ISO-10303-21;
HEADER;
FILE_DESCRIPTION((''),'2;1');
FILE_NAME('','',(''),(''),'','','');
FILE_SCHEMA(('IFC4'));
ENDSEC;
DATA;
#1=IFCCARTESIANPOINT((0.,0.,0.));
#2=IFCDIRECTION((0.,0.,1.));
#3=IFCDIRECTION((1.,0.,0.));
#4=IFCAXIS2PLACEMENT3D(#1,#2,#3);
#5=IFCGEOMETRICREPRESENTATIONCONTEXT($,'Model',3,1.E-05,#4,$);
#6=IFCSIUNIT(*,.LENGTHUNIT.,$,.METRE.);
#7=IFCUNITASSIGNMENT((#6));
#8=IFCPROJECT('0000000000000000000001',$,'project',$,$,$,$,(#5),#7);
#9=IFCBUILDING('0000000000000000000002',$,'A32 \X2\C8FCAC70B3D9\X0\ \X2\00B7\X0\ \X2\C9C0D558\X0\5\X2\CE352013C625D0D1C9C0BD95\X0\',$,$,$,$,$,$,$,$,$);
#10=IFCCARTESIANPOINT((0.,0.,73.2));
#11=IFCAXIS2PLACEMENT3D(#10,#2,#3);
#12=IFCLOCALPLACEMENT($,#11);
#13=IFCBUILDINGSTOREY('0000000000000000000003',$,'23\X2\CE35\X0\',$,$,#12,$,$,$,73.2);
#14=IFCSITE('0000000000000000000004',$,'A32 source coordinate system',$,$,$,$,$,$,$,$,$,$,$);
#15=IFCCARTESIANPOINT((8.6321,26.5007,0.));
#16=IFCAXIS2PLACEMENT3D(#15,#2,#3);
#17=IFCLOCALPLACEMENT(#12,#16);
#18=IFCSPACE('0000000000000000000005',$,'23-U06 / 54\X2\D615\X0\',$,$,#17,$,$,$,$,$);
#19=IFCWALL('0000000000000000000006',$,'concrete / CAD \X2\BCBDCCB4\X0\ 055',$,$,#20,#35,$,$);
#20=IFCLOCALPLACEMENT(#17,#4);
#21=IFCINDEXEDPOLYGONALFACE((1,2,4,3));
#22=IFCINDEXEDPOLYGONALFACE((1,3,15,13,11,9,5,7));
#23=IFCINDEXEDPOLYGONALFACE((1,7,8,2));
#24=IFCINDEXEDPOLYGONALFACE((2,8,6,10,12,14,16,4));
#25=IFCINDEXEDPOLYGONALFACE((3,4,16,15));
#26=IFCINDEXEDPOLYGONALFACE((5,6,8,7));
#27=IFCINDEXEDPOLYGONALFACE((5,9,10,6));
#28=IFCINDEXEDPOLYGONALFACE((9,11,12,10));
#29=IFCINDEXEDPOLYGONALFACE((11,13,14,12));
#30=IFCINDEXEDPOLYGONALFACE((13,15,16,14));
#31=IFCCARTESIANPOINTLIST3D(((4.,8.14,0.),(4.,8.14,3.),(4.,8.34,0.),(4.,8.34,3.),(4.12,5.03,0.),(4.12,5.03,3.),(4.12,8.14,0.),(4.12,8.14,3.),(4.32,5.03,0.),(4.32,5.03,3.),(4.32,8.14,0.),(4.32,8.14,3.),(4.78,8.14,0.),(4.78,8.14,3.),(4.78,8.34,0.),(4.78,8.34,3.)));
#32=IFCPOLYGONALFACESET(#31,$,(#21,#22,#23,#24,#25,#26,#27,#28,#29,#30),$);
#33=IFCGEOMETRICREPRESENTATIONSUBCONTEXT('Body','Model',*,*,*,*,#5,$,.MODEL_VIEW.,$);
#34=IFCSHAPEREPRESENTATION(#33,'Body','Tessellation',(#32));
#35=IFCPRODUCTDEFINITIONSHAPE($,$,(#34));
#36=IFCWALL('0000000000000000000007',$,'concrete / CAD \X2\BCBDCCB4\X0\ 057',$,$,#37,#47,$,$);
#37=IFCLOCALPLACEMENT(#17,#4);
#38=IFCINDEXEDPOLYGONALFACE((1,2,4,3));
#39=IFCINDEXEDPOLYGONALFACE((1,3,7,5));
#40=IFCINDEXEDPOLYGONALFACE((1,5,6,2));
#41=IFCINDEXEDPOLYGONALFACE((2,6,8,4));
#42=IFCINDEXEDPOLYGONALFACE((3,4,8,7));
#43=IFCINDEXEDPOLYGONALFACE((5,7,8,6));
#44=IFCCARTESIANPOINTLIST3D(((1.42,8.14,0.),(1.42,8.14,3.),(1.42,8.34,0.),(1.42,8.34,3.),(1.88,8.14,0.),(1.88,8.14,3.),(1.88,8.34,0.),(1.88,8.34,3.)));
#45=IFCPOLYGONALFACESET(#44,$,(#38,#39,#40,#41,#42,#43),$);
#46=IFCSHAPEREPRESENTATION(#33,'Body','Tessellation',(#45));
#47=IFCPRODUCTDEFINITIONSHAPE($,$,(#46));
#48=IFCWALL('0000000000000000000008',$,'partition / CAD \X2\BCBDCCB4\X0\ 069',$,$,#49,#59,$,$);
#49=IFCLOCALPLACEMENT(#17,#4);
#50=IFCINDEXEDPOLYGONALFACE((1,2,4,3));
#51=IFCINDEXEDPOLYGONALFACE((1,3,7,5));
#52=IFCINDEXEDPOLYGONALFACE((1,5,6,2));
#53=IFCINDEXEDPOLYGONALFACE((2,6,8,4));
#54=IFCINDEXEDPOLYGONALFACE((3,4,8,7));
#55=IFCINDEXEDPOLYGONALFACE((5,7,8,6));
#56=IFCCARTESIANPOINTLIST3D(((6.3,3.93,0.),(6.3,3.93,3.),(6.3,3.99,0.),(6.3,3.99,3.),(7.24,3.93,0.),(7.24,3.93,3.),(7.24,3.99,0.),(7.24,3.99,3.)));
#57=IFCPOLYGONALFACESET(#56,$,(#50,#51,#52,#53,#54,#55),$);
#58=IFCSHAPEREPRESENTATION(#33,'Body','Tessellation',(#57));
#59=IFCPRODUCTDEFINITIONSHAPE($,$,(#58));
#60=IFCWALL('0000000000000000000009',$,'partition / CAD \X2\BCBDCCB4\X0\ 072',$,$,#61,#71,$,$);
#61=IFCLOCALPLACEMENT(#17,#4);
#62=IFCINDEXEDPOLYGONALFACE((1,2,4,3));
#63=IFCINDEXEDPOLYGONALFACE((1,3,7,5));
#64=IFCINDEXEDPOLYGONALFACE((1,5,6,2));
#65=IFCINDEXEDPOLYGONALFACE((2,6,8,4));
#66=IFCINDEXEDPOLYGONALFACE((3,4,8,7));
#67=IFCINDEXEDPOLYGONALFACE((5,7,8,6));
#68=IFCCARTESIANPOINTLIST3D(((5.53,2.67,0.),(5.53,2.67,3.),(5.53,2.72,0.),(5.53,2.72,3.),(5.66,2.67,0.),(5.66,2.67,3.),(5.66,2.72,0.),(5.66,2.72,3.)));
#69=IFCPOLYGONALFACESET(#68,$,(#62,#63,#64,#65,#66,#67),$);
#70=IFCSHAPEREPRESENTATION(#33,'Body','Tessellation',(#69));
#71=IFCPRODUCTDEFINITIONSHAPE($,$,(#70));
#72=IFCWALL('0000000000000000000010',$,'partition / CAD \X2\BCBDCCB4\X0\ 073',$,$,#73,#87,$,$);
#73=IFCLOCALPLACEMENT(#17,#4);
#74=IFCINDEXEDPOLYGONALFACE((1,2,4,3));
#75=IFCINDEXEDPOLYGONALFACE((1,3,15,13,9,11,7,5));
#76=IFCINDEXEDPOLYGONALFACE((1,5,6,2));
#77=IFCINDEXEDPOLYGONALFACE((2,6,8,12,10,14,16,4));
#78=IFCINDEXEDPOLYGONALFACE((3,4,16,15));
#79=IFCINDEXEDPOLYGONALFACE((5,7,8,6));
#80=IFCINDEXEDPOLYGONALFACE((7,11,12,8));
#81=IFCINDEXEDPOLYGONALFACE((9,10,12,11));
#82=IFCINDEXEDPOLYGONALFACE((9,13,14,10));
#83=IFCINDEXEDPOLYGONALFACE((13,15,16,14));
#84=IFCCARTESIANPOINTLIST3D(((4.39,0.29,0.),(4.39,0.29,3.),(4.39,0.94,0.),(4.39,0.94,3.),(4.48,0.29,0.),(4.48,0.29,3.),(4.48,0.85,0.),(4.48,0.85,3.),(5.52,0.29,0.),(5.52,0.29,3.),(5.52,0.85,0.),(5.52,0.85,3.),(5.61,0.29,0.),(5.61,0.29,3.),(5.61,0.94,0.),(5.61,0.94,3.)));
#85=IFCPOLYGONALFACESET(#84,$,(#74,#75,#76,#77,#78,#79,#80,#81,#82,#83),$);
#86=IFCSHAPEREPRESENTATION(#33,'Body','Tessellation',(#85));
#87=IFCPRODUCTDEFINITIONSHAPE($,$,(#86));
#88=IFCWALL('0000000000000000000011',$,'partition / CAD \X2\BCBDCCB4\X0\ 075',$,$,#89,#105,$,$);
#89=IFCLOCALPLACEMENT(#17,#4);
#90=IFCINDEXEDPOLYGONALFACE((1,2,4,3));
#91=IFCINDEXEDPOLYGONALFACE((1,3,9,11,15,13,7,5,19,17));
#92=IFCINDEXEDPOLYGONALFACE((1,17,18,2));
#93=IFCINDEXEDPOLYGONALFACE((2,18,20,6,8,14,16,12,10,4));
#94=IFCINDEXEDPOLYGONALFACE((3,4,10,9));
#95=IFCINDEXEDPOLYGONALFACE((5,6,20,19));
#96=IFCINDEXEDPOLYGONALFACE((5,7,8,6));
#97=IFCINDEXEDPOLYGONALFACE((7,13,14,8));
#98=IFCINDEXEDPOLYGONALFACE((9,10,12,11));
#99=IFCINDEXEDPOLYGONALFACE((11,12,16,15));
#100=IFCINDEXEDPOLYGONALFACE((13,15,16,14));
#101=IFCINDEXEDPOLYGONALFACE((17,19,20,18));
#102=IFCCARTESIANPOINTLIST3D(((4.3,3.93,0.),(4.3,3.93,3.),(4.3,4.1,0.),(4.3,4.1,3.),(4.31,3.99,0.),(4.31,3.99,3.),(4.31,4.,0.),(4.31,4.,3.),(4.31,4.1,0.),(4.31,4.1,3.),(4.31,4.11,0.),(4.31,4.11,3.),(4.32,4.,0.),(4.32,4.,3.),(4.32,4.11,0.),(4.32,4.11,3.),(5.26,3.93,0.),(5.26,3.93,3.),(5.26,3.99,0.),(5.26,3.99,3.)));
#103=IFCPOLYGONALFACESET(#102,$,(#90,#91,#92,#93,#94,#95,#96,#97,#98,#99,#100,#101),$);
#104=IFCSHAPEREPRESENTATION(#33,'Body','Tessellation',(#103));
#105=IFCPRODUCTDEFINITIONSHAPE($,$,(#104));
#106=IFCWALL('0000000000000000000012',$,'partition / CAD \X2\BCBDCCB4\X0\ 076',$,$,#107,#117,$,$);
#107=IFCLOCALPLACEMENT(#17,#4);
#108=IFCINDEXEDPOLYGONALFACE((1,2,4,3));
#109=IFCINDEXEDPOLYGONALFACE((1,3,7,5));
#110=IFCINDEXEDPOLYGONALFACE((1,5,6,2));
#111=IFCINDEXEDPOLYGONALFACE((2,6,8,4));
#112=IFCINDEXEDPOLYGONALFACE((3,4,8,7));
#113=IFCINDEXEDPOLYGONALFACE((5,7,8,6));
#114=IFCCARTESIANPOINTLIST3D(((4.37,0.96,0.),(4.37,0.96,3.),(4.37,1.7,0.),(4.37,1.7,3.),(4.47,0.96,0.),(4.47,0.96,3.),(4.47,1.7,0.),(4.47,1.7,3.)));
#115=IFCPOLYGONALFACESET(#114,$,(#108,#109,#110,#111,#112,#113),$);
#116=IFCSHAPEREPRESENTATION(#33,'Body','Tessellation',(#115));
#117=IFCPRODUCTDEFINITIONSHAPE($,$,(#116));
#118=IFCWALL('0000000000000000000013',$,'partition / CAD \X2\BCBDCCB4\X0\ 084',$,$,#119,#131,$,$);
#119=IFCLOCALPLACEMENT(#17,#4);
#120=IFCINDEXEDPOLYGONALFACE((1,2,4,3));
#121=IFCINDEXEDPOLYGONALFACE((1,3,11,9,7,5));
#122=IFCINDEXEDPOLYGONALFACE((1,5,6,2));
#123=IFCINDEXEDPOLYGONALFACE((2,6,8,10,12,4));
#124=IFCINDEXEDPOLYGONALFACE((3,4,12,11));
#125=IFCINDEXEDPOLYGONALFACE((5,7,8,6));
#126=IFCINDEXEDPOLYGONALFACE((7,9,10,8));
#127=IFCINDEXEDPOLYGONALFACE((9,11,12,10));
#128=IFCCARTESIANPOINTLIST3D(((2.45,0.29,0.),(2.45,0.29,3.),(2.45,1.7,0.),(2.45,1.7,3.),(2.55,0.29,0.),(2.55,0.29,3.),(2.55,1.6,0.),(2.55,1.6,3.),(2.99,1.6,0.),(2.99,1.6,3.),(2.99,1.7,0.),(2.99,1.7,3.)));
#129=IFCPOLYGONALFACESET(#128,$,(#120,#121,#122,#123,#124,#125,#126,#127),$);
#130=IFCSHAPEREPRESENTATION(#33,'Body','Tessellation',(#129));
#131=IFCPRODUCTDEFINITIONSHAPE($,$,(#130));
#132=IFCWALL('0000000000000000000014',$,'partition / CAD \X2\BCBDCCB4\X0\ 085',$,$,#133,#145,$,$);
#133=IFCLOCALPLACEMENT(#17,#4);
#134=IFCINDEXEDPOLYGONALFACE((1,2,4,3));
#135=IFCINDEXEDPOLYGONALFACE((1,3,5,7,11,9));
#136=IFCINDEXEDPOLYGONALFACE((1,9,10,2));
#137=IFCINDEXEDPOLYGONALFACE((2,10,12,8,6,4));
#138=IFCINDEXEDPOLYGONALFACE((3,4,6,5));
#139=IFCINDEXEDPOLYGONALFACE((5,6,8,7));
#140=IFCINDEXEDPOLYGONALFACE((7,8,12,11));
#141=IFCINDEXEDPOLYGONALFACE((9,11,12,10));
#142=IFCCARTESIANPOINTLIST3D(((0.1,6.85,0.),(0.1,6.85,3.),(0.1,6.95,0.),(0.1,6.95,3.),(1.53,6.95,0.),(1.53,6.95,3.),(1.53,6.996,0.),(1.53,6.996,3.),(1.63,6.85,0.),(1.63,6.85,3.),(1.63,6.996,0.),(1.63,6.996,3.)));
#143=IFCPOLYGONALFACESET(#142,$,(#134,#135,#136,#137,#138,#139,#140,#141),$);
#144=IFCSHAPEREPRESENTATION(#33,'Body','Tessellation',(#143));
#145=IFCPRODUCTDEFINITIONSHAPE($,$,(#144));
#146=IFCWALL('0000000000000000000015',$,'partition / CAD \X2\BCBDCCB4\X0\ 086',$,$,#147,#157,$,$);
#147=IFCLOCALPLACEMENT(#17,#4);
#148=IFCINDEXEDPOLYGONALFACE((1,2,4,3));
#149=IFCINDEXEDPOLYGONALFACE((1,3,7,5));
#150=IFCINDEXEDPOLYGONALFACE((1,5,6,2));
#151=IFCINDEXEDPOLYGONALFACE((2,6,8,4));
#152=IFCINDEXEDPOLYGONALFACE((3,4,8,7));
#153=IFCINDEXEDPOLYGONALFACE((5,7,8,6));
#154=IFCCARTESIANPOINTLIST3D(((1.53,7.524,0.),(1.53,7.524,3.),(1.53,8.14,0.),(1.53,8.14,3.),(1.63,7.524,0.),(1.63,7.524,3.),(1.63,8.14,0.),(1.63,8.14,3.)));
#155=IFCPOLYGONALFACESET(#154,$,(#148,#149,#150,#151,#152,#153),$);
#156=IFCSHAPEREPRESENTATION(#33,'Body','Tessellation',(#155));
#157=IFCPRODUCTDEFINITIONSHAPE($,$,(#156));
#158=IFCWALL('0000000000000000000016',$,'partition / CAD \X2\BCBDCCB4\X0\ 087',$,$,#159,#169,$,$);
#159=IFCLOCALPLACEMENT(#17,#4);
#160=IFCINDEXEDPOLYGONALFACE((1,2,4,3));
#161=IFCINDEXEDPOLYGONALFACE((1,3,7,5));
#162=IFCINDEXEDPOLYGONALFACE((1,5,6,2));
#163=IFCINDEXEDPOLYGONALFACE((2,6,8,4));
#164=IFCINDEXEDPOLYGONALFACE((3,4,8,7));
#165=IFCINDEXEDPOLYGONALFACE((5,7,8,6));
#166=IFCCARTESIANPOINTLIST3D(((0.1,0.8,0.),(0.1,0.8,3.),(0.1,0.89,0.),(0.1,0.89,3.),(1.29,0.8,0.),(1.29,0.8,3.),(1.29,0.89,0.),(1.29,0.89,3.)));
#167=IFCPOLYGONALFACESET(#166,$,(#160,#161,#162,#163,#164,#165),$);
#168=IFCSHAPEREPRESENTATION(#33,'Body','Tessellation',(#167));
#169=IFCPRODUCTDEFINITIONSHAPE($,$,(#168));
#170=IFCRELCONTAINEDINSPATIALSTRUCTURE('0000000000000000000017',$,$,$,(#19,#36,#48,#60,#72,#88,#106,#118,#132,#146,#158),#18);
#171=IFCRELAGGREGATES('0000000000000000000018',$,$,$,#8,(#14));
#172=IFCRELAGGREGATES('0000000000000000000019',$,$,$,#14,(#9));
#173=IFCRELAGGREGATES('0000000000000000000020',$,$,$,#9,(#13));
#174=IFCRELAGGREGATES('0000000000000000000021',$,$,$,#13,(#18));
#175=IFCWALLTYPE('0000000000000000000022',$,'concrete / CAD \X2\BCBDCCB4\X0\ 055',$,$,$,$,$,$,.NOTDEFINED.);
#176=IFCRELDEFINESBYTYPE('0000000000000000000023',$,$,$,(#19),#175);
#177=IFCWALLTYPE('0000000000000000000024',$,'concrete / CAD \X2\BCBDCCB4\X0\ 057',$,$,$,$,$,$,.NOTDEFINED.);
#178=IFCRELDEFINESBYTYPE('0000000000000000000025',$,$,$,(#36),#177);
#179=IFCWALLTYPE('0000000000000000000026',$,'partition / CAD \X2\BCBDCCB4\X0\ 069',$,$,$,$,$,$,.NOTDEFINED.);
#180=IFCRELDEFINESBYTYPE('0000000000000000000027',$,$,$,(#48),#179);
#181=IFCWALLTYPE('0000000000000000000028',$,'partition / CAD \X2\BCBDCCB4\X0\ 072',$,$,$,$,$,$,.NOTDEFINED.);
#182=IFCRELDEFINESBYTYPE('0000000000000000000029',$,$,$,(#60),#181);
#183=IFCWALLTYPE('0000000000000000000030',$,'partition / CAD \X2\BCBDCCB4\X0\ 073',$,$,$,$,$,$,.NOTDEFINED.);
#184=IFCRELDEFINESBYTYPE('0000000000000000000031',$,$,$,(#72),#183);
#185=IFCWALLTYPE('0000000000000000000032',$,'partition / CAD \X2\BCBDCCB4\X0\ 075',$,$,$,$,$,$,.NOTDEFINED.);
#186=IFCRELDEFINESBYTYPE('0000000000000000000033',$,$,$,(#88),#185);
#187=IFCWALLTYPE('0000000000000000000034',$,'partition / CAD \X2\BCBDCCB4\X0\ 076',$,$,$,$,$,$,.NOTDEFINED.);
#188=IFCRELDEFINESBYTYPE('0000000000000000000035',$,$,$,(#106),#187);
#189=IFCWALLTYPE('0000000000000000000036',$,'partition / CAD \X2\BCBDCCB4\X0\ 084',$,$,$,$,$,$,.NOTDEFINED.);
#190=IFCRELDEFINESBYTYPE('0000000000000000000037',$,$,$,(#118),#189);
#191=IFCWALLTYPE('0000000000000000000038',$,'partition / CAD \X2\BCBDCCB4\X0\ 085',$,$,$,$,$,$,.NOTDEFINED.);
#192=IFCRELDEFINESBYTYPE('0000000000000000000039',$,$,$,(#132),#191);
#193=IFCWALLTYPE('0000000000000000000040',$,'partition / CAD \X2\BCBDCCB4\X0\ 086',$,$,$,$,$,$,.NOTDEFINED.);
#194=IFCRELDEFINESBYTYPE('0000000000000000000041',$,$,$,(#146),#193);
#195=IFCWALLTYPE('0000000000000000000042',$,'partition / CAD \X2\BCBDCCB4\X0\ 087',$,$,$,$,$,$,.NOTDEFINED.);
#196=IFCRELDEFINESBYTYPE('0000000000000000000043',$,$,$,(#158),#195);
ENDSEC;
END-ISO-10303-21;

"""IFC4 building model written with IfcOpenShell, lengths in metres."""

from ifc_helpers import new_model, si_unit, frame, origin, origin_with_axes, place, context, subcontext, project, spatial, polyline, outline, extrude, source, transform, mapped, type_object, type_shapes, element, save


model = new_model("IFC4")

# Units and contexts
model_context = context("Model", 3, precision=1e-05, world=origin_with_axes())
body_context = subcontext(model_context, "Body", "Model", "MODEL_VIEW")
ifc_project = project(units=[si_unit("LENGTHUNIT", "METRE")], contexts=[model_context])

# Site, building, storey, space
site = spatial("IfcSite", under=ifc_project, Name="A32 source coordinate system")
building = spatial("IfcBuilding", under=site, Name="A32 주거동 · 지하5층–옥탑지붕")
storey_placement = place(None, frame((0.0, 0.0, 73.2), z_axis=(0.0, 0.0, 1.0), x_axis=(1.0, 0.0, 0.0)))
storey = spatial("IfcBuildingStorey", under=building, at=storey_placement, Name="23층", Elevation=73.2)
space_placement = place(storey_placement, frame((8.6321, 26.5007, 0.0), z_axis=(0.0, 0.0, 1.0), x_axis=(1.0, 0.0, 0.0)))
space = spatial("IfcSpace", under=storey, at=space_placement, Name="23-U06 / 54형")

# Walls
wall_type_1 = type_object("IfcWallType", Name="concrete / CAD 벽체 055", PredefinedType="NOTDEFINED")
shared_shape_1 = source(origin(), body_context, "Body", "SweptSolid", [
    extrude(outline(polyline([(4.32, 5.03), (4.12, 5.03), (4.12, 8.14), (4.0, 8.14), (4.0, 8.34), (4.78, 8.34), (4.78, 8.14), (4.32, 8.14), (4.32, 5.03)])), origin(), (0.0, 0.0, 1.0), 3.0),
])
type_shapes(wall_type_1, [shared_shape_1])
wall_1_placement = place(space_placement, origin_with_axes())
element("IfcWall", 1, at=wall_1_placement, inside=space, type_object=wall_type_1, Name="concrete / CAD 벽체 055", context=body_context, shape_type="MappedRepresentation", body=[
    mapped(shared_shape_1, transform((0.0, 0.0, 0.0), scale=1.0)),
])
wall_type_2 = type_object("IfcWallType", Name="concrete / CAD 벽체 057", PredefinedType="NOTDEFINED")
shared_shape_2 = source(origin(), body_context, "Body", "SweptSolid", [
    extrude(outline(polyline([(1.42, 8.14), (1.42, 8.34), (1.88, 8.34), (1.88, 8.14), (1.42, 8.14)])), origin(), (0.0, 0.0, 1.0), 3.0),
])
type_shapes(wall_type_2, [shared_shape_2])
wall_2_placement = place(space_placement, origin_with_axes())
element("IfcWall", 2, at=wall_2_placement, inside=space, type_object=wall_type_2, Name="concrete / CAD 벽체 057", context=body_context, shape_type="MappedRepresentation", body=[
    mapped(shared_shape_2, transform((0.0, 0.0, 0.0), scale=1.0)),
])
wall_type_3 = type_object("IfcWallType", Name="partition / CAD 벽체 069", PredefinedType="NOTDEFINED")
shared_shape_3 = source(origin(), body_context, "Body", "SweptSolid", [
    extrude(outline(polyline([(7.24, 3.93), (6.3, 3.93), (6.3, 3.99), (7.24, 3.99), (7.24, 3.93)])), origin(), (0.0, 0.0, 1.0), 3.0),
])
type_shapes(wall_type_3, [shared_shape_3])
wall_3_placement = place(space_placement, origin_with_axes())
element("IfcWall", 3, at=wall_3_placement, inside=space, type_object=wall_type_3, Name="partition / CAD 벽체 069", context=body_context, shape_type="MappedRepresentation", body=[
    mapped(shared_shape_3, transform((0.0, 0.0, 0.0), scale=1.0)),
])
wall_type_4 = type_object("IfcWallType", Name="partition / CAD 벽체 072", PredefinedType="NOTDEFINED")
shared_shape_4 = source(origin(), body_context, "Body", "SweptSolid", [
    extrude(outline(polyline([(5.66, 2.67), (5.53, 2.67), (5.53, 2.72), (5.66, 2.72), (5.66, 2.67)])), origin(), (0.0, 0.0, 1.0), 3.0),
])
type_shapes(wall_type_4, [shared_shape_4])
wall_4_placement = place(space_placement, origin_with_axes())
element("IfcWall", 4, at=wall_4_placement, inside=space, type_object=wall_type_4, Name="partition / CAD 벽체 072", context=body_context, shape_type="MappedRepresentation", body=[
    mapped(shared_shape_4, transform((0.0, 0.0, 0.0), scale=1.0)),
])
wall_type_5 = type_object("IfcWallType", Name="partition / CAD 벽체 073", PredefinedType="NOTDEFINED")
shared_shape_5 = source(origin(), body_context, "Body", "SweptSolid", [
    extrude(outline(polyline([(4.48, 0.29), (4.39, 0.29), (4.39, 0.94), (5.61, 0.94), (5.61, 0.29), (5.52, 0.29), (5.52, 0.85), (4.48, 0.85), (4.48, 0.29)])), origin(), (0.0, 0.0, 1.0), 3.0),
])
type_shapes(wall_type_5, [shared_shape_5])
wall_5_placement = place(space_placement, origin_with_axes())
element("IfcWall", 5, at=wall_5_placement, inside=space, type_object=wall_type_5, Name="partition / CAD 벽체 073", context=body_context, shape_type="MappedRepresentation", body=[
    mapped(shared_shape_5, transform((0.0, 0.0, 0.0), scale=1.0)),
])
wall_type_6 = type_object("IfcWallType", Name="partition / CAD 벽체 075", PredefinedType="NOTDEFINED")
shared_shape_6 = source(origin(), body_context, "Body", "SweptSolid", [
    extrude(outline(polyline([(4.32, 4.0), (4.31, 4.0), (4.31, 3.99), (5.26, 3.99), (5.26, 3.93), (4.3, 3.93), (4.3, 4.1), (4.31, 4.1), (4.31, 4.11), (4.32, 4.11), (4.32, 4.0)])), origin(), (0.0, 0.0, 1.0), 3.0),
])
type_shapes(wall_type_6, [shared_shape_6])
wall_6_placement = place(space_placement, origin_with_axes())
element("IfcWall", 6, at=wall_6_placement, inside=space, type_object=wall_type_6, Name="partition / CAD 벽체 075", context=body_context, shape_type="MappedRepresentation", body=[
    mapped(shared_shape_6, transform((0.0, 0.0, 0.0), scale=1.0)),
])
wall_type_7 = type_object("IfcWallType", Name="partition / CAD 벽체 076", PredefinedType="NOTDEFINED")
shared_shape_7 = source(origin(), body_context, "Body", "SweptSolid", [
    extrude(outline(polyline([(4.37, 1.7), (4.47, 1.7), (4.47, 0.96), (4.37, 0.96), (4.37, 1.7)])), origin(), (0.0, 0.0, 1.0), 3.0),
])
type_shapes(wall_type_7, [shared_shape_7])
wall_7_placement = place(space_placement, origin_with_axes())
element("IfcWall", 7, at=wall_7_placement, inside=space, type_object=wall_type_7, Name="partition / CAD 벽체 076", context=body_context, shape_type="MappedRepresentation", body=[
    mapped(shared_shape_7, transform((0.0, 0.0, 0.0), scale=1.0)),
])
wall_type_8 = type_object("IfcWallType", Name="partition / CAD 벽체 084", PredefinedType="NOTDEFINED")
shared_shape_8 = source(origin(), body_context, "Body", "SweptSolid", [
    extrude(outline(polyline([(2.99, 1.6), (2.55, 1.6), (2.55, 0.29), (2.45, 0.29), (2.45, 1.7), (2.99, 1.7), (2.99, 1.6)])), origin(), (0.0, 0.0, 1.0), 3.0),
])
type_shapes(wall_type_8, [shared_shape_8])
wall_8_placement = place(space_placement, origin_with_axes())
element("IfcWall", 8, at=wall_8_placement, inside=space, type_object=wall_type_8, Name="partition / CAD 벽체 084", context=body_context, shape_type="MappedRepresentation", body=[
    mapped(shared_shape_8, transform((0.0, 0.0, 0.0), scale=1.0)),
])
wall_type_9 = type_object("IfcWallType", Name="partition / CAD 벽체 085", PredefinedType="NOTDEFINED")
shared_shape_9 = source(origin(), body_context, "Body", "SweptSolid", [
    extrude(outline(polyline([(1.63, 6.85), (0.1, 6.85), (0.1, 6.95), (1.53, 6.95), (1.53, 6.996), (1.63, 6.996), (1.63, 6.85)])), origin(), (0.0, 0.0, 1.0), 3.0),
])
type_shapes(wall_type_9, [shared_shape_9])
wall_9_placement = place(space_placement, origin_with_axes())
element("IfcWall", 9, at=wall_9_placement, inside=space, type_object=wall_type_9, Name="partition / CAD 벽체 085", context=body_context, shape_type="MappedRepresentation", body=[
    mapped(shared_shape_9, transform((0.0, 0.0, 0.0), scale=1.0)),
])
wall_type_10 = type_object("IfcWallType", Name="partition / CAD 벽체 086", PredefinedType="NOTDEFINED")
shared_shape_10 = source(origin(), body_context, "Body", "SweptSolid", [
    extrude(outline(polyline([(1.53, 7.524), (1.53, 8.14), (1.63, 8.14), (1.63, 7.524), (1.53, 7.524)])), origin(), (0.0, 0.0, 1.0), 3.0),
])
type_shapes(wall_type_10, [shared_shape_10])
wall_10_placement = place(space_placement, origin_with_axes())
element("IfcWall", 10, at=wall_10_placement, inside=space, type_object=wall_type_10, Name="partition / CAD 벽체 086", context=body_context, shape_type="MappedRepresentation", body=[
    mapped(shared_shape_10, transform((0.0, 0.0, 0.0), scale=1.0)),
])
wall_type_11 = type_object("IfcWallType", Name="partition / CAD 벽체 087", PredefinedType="NOTDEFINED")
shared_shape_11 = source(origin(), body_context, "Body", "SweptSolid", [
    extrude(outline(polyline([(1.29, 0.8), (0.1, 0.8), (0.1, 0.89), (1.29, 0.89), (1.29, 0.8)])), origin(), (0.0, 0.0, 1.0), 3.0),
])
type_shapes(wall_type_11, [shared_shape_11])
wall_11_placement = place(space_placement, origin_with_axes())
element("IfcWall", 11, at=wall_11_placement, inside=space, type_object=wall_type_11, Name="partition / CAD 벽체 087", context=body_context, shape_type="MappedRepresentation", body=[
    mapped(shared_shape_11, transform((0.0, 0.0, 0.0), scale=1.0)),
])

save(model, "model.ifc")
